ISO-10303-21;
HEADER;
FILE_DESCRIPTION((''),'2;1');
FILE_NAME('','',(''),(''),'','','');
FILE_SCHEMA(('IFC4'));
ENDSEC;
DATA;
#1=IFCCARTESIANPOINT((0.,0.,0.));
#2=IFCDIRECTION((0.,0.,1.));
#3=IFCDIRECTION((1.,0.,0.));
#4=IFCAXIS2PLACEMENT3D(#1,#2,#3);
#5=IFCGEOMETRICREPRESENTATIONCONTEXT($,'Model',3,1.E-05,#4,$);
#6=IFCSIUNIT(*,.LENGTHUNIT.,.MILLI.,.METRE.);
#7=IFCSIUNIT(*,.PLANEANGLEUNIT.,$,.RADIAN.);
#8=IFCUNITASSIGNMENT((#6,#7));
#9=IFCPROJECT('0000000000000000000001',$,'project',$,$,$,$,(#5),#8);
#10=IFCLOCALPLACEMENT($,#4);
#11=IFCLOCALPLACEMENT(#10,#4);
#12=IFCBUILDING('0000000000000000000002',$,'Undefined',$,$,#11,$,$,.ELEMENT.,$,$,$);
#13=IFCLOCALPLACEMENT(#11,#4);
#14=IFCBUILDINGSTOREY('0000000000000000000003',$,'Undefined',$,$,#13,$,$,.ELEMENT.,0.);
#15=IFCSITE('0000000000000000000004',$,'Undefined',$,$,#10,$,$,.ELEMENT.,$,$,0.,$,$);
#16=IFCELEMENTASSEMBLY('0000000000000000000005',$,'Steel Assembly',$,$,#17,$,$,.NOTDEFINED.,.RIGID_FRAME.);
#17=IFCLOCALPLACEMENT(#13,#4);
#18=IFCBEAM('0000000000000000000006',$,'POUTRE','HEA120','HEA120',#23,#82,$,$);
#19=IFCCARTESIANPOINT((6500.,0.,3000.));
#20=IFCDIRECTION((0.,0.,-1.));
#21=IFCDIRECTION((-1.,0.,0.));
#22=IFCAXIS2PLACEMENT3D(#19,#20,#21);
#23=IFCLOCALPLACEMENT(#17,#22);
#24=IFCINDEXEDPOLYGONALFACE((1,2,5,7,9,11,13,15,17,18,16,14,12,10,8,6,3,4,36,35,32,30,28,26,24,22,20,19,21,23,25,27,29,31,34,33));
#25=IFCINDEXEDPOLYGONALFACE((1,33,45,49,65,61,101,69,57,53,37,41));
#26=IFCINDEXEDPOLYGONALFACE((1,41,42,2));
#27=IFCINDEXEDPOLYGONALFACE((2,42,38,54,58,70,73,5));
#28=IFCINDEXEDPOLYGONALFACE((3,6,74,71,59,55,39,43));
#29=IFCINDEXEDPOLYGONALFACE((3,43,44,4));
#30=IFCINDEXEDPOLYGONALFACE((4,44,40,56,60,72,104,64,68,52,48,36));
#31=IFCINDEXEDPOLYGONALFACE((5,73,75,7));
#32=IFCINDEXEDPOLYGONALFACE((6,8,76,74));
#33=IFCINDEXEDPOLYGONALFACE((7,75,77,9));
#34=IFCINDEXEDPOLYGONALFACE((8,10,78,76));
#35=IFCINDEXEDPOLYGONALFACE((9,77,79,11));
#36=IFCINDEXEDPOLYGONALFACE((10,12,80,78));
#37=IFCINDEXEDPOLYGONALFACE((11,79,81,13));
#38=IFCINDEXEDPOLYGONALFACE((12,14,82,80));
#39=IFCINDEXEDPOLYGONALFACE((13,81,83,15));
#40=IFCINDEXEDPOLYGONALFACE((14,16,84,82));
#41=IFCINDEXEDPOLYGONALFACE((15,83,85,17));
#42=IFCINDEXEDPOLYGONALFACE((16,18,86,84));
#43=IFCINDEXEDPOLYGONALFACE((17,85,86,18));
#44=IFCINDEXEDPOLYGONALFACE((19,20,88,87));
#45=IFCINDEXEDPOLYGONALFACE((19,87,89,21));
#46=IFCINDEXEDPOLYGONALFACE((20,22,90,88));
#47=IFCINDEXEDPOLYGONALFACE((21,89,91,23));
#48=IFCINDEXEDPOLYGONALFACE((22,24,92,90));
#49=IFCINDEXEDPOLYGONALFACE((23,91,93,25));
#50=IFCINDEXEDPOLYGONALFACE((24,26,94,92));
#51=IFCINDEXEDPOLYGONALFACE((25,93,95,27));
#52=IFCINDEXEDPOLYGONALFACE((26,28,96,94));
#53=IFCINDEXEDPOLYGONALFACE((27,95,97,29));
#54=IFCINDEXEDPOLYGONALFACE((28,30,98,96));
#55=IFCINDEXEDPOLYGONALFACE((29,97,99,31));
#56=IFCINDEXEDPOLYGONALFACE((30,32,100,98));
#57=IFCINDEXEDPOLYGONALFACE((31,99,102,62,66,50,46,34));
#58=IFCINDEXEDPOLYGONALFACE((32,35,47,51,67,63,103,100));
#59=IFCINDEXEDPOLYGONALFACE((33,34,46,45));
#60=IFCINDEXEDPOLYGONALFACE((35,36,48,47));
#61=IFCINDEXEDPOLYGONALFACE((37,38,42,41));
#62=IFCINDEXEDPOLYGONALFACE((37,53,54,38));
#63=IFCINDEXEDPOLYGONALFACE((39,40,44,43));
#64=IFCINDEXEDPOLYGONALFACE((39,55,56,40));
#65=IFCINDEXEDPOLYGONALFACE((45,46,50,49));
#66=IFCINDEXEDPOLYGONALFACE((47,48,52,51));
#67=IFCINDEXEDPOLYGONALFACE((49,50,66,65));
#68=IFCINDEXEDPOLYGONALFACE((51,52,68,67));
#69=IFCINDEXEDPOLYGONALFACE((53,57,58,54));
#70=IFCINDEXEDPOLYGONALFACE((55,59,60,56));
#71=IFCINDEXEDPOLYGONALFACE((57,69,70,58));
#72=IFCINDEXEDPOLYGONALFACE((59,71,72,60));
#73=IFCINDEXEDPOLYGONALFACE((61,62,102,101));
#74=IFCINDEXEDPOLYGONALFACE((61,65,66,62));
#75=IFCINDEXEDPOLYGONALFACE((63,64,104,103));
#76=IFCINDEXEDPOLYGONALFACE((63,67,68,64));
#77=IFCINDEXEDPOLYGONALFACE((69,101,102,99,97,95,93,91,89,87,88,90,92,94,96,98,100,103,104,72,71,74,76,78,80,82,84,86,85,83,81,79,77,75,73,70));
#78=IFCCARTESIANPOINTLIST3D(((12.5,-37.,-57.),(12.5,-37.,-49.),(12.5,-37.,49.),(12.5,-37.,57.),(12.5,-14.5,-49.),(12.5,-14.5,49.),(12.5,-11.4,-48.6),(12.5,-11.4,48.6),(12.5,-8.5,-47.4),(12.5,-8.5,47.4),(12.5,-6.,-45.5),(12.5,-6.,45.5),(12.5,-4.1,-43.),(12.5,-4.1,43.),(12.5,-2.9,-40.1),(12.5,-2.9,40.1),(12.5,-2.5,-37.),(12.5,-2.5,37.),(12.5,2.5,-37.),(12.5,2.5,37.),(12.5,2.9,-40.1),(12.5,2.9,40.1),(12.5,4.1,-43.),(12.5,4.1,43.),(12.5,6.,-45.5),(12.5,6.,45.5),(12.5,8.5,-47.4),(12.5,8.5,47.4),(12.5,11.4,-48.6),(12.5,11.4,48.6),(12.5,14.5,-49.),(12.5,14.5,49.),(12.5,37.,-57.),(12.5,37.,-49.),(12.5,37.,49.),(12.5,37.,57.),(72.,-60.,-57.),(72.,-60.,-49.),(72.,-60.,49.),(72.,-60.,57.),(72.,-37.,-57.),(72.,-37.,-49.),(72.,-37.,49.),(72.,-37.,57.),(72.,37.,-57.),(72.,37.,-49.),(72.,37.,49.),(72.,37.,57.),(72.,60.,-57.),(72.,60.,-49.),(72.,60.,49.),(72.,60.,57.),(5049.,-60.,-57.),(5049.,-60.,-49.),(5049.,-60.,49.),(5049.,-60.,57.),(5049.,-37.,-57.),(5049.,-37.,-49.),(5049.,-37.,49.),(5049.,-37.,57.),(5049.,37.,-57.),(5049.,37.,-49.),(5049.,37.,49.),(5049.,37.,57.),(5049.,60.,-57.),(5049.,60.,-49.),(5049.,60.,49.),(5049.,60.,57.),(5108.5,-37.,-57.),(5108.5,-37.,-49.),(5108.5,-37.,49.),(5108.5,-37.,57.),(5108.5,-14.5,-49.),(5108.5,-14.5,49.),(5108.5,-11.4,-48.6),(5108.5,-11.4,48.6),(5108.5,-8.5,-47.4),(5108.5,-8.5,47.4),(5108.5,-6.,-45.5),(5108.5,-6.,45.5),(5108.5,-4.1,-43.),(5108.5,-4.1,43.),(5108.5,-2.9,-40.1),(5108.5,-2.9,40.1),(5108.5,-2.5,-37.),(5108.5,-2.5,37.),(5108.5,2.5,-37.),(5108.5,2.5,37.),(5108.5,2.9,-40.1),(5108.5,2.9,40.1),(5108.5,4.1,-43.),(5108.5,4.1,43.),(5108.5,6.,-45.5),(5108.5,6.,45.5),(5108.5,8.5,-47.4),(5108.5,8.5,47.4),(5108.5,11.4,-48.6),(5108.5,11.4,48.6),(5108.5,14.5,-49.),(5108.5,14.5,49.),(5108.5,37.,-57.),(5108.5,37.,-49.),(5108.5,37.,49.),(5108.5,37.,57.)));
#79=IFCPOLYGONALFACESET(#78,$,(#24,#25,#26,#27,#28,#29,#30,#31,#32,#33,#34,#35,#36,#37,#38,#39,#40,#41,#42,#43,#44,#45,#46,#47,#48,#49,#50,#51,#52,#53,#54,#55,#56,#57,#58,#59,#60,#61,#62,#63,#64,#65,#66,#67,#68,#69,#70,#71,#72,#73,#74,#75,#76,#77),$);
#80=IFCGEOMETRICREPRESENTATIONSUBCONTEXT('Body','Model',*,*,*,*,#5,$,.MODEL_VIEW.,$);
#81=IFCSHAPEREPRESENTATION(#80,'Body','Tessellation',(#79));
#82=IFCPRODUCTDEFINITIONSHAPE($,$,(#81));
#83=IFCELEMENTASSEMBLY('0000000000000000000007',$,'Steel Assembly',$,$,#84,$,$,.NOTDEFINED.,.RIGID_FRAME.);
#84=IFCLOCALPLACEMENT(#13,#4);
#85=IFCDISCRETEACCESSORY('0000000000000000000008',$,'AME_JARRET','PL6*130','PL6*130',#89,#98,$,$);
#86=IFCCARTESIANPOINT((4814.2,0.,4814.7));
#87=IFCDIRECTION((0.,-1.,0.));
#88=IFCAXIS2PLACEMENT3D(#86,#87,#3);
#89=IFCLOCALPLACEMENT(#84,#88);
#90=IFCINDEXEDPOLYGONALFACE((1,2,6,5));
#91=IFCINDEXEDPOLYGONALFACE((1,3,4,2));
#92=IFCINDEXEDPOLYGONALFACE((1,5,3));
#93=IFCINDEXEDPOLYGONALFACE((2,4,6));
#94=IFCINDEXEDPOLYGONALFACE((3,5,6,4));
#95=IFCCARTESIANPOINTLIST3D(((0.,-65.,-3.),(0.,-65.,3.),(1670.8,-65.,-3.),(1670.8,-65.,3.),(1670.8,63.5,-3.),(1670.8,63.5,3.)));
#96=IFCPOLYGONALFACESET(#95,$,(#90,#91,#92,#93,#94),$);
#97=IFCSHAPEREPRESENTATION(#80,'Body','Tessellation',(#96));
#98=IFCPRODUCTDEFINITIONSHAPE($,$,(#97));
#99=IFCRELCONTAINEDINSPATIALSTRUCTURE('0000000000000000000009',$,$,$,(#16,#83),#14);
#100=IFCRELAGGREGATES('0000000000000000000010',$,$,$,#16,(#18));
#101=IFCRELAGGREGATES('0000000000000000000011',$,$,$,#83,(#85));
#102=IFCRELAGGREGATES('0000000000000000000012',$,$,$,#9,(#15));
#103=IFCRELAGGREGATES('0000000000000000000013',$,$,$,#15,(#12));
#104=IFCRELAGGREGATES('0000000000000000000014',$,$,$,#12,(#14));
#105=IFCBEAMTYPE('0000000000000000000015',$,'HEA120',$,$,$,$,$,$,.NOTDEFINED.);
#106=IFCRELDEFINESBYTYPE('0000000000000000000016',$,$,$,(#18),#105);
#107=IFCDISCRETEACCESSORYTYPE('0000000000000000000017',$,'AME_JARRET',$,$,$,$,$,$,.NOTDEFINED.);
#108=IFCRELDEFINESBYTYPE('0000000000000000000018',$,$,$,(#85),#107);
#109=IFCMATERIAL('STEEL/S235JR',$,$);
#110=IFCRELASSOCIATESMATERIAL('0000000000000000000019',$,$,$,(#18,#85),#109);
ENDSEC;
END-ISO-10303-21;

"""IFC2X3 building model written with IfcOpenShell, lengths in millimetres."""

from ifc_helpers import new_model, si_unit, frame, origin_with_axes, origin_2d_with_axis, place, context, subcontext, project, spatial, polyline, i_section, outline, extrude, boolean, clip, halfspace, material, type_object, element, aggregate, save


model = new_model("IFC2X3")

# Units and contexts
model_context = context("Model", 3, precision=1e-05, world=origin_with_axes())
body_context = subcontext(model_context, "Body", "Model", "MODEL_VIEW")
ifc_project = project(units=[si_unit("LENGTHUNIT", "METRE", prefix="MILLI"), si_unit("PLANEANGLEUNIT", "RADIAN")], contexts=[model_context])

# Site, building, storey
site_placement = place(None, origin_with_axes())
site = spatial("IfcSite", under=ifc_project, at=site_placement, Name="Undefined", CompositionType="ELEMENT", RefElevation=0.0)
building_placement = place(site_placement, origin_with_axes())
building = spatial("IfcBuilding", under=site, at=building_placement, Name="Undefined", CompositionType="ELEMENT")
storey_placement = place(building_placement, origin_with_axes())
storey = spatial("IfcBuildingStorey", under=building, at=storey_placement, Name="Undefined", CompositionType="ELEMENT", Elevation=0.0)

# Element assembly, beam
ifc_material_1 = material(Name="STEEL/S235JR")
assembly_1_placement = place(storey_placement, origin_with_axes())
assembly_1 = element("IfcElementAssembly", 1, at=assembly_1_placement, inside=storey, Name="Steel Assembly", AssemblyPlace="NOTDEFINED", PredefinedType="RIGID_FRAME")
beam_type_1 = type_object("IfcBeamType", Name="HEA120", PredefinedType="NOTDEFINED")
beam_1_placement = place(assembly_1_placement, frame((6500.0, 0.0, 3000.0), z_axis=(0.0, 0.0, -1.0), x_axis=(-1.0, 0.0, 0.0)))
beam_1 = element("IfcBeam", 2, at=beam_1_placement, type_object=beam_type_1, material=ifc_material_1, Name="POUTRE", Description="HEA120", ObjectType="HEA120", context=body_context, shape_type="CSG", body=[
    boolean("DIFFERENCE", boolean("DIFFERENCE", boolean("DIFFERENCE", boolean("DIFFERENCE", boolean("DIFFERENCE", boolean("DIFFERENCE", extrude(i_section(OverallWidth=120.0, OverallDepth=114.0, WebThickness=5.0, FlangeThickness=8.0, FilletRadius=12.0, at=origin_2d_with_axis()), frame((5108.5, 0.0, 0.0), z_axis=(-1.0, 0.0, 0.0), x_axis=(0.0, -1.0, 0.0)), (0.0, 0.0, 1.0), 5096.0), extrude(outline(polyline([(0.0, 0.0), (69.5, 0.0), (69.5, 33.0), (0.0, 33.0), (0.0, 0.0)])), frame((2.5, -37.0, 67.0), z_axis=(0.0, 0.0, -1.0), x_axis=(1.0, 0.0, 0.0)), (0.0, 0.0, 1.0), 134.0)), extrude(outline(polyline([(0.0, 0.0), (69.5, 0.0), (69.5, 33.0), (0.0, 33.0), (0.0, 0.0)])), frame((2.5, 37.0, -67.0), z_axis=(0.0, 0.0, 1.0), x_axis=(1.0, 0.0, 0.0)), (0.0, 0.0, 1.0), 134.0)), extrude(outline(polyline([(0.0, 0.0), (69.5, 0.0), (69.5, 33.0), (0.0, 33.0), (0.0, 0.0)])), frame((5118.5, 37.0, 67.0), z_axis=(0.0, 0.0, -1.0), x_axis=(-1.0, 0.0, 0.0)), (0.0, 0.0, 1.0), 134.0)), extrude(outline(polyline([(0.0, 0.0), (69.5, 0.0), (69.5, 33.0), (0.0, 33.0), (0.0, 0.0)])), frame((5118.5, -37.0, -67.0), z_axis=(0.0, 0.0, 1.0), x_axis=(-1.0, 0.0, 0.0)), (0.0, 0.0, 1.0), 134.0)), halfspace(frame((5108.5, 0.0, 57.0), z_axis=(-1.0, 0.0, 0.0), x_axis=(0.0, -1.0, 0.0)), True)), halfspace(frame((12.5, 0.0, 57.0), z_axis=(1.0, 0.0, 0.0), x_axis=(0.0, 1.0, 0.0)), True)),
])

# Element assembly
assembly_2_placement = place(storey_placement, origin_with_axes())
assembly_2 = element("IfcElementAssembly", 3, at=assembly_2_placement, inside=storey, Name="Steel Assembly", AssemblyPlace="NOTDEFINED", PredefinedType="RIGID_FRAME")

aggregate(assembly_1, [beam_1])

# Discrete accessory
discrete_accessory_type_1 = type_object("IfcDiscreteAccessoryType", Name="AME_JARRET")
discrete_accessory_1_placement = place(assembly_2_placement, frame((4814.2, 0.0, 4814.7), z_axis=(0.0, -1.0, 0.0), x_axis=(1.0, 0.0, 0.0)))
discrete_accessory_1 = element("IfcDiscreteAccessory", 4, at=discrete_accessory_1_placement, type_object=discrete_accessory_type_1, material=ifc_material_1, Name="AME_JARRET", Description="PL6*130", ObjectType="PL6*130", context=body_context, shape_type="Clipping", body=[
    clip(clip(extrude(outline(polyline([(1670.8, -65.0), (0.0, -65.0), (1670.8, 63.5), (1670.8, -65.0)])), frame((0.0, 0.0, -3.0), z_axis=(0.0, 0.0, 1.0), x_axis=(1.0, 0.0, 0.0)), (0.0, 0.0, 1.0), 6.0), halfspace(frame((1670.8, 63.5, -3.0), z_axis=(-0.076696, 0.997054, 0.0), x_axis=(0.0, 0.0, 1.0)), False)), halfspace(frame((1670.8, -65.0, 3.0), z_axis=(1.0, 0.0, 0.0), x_axis=(0.0, 1.0, 0.0)), False)),
])
aggregate(assembly_2, [discrete_accessory_1])

save(model, "model.ifc")
